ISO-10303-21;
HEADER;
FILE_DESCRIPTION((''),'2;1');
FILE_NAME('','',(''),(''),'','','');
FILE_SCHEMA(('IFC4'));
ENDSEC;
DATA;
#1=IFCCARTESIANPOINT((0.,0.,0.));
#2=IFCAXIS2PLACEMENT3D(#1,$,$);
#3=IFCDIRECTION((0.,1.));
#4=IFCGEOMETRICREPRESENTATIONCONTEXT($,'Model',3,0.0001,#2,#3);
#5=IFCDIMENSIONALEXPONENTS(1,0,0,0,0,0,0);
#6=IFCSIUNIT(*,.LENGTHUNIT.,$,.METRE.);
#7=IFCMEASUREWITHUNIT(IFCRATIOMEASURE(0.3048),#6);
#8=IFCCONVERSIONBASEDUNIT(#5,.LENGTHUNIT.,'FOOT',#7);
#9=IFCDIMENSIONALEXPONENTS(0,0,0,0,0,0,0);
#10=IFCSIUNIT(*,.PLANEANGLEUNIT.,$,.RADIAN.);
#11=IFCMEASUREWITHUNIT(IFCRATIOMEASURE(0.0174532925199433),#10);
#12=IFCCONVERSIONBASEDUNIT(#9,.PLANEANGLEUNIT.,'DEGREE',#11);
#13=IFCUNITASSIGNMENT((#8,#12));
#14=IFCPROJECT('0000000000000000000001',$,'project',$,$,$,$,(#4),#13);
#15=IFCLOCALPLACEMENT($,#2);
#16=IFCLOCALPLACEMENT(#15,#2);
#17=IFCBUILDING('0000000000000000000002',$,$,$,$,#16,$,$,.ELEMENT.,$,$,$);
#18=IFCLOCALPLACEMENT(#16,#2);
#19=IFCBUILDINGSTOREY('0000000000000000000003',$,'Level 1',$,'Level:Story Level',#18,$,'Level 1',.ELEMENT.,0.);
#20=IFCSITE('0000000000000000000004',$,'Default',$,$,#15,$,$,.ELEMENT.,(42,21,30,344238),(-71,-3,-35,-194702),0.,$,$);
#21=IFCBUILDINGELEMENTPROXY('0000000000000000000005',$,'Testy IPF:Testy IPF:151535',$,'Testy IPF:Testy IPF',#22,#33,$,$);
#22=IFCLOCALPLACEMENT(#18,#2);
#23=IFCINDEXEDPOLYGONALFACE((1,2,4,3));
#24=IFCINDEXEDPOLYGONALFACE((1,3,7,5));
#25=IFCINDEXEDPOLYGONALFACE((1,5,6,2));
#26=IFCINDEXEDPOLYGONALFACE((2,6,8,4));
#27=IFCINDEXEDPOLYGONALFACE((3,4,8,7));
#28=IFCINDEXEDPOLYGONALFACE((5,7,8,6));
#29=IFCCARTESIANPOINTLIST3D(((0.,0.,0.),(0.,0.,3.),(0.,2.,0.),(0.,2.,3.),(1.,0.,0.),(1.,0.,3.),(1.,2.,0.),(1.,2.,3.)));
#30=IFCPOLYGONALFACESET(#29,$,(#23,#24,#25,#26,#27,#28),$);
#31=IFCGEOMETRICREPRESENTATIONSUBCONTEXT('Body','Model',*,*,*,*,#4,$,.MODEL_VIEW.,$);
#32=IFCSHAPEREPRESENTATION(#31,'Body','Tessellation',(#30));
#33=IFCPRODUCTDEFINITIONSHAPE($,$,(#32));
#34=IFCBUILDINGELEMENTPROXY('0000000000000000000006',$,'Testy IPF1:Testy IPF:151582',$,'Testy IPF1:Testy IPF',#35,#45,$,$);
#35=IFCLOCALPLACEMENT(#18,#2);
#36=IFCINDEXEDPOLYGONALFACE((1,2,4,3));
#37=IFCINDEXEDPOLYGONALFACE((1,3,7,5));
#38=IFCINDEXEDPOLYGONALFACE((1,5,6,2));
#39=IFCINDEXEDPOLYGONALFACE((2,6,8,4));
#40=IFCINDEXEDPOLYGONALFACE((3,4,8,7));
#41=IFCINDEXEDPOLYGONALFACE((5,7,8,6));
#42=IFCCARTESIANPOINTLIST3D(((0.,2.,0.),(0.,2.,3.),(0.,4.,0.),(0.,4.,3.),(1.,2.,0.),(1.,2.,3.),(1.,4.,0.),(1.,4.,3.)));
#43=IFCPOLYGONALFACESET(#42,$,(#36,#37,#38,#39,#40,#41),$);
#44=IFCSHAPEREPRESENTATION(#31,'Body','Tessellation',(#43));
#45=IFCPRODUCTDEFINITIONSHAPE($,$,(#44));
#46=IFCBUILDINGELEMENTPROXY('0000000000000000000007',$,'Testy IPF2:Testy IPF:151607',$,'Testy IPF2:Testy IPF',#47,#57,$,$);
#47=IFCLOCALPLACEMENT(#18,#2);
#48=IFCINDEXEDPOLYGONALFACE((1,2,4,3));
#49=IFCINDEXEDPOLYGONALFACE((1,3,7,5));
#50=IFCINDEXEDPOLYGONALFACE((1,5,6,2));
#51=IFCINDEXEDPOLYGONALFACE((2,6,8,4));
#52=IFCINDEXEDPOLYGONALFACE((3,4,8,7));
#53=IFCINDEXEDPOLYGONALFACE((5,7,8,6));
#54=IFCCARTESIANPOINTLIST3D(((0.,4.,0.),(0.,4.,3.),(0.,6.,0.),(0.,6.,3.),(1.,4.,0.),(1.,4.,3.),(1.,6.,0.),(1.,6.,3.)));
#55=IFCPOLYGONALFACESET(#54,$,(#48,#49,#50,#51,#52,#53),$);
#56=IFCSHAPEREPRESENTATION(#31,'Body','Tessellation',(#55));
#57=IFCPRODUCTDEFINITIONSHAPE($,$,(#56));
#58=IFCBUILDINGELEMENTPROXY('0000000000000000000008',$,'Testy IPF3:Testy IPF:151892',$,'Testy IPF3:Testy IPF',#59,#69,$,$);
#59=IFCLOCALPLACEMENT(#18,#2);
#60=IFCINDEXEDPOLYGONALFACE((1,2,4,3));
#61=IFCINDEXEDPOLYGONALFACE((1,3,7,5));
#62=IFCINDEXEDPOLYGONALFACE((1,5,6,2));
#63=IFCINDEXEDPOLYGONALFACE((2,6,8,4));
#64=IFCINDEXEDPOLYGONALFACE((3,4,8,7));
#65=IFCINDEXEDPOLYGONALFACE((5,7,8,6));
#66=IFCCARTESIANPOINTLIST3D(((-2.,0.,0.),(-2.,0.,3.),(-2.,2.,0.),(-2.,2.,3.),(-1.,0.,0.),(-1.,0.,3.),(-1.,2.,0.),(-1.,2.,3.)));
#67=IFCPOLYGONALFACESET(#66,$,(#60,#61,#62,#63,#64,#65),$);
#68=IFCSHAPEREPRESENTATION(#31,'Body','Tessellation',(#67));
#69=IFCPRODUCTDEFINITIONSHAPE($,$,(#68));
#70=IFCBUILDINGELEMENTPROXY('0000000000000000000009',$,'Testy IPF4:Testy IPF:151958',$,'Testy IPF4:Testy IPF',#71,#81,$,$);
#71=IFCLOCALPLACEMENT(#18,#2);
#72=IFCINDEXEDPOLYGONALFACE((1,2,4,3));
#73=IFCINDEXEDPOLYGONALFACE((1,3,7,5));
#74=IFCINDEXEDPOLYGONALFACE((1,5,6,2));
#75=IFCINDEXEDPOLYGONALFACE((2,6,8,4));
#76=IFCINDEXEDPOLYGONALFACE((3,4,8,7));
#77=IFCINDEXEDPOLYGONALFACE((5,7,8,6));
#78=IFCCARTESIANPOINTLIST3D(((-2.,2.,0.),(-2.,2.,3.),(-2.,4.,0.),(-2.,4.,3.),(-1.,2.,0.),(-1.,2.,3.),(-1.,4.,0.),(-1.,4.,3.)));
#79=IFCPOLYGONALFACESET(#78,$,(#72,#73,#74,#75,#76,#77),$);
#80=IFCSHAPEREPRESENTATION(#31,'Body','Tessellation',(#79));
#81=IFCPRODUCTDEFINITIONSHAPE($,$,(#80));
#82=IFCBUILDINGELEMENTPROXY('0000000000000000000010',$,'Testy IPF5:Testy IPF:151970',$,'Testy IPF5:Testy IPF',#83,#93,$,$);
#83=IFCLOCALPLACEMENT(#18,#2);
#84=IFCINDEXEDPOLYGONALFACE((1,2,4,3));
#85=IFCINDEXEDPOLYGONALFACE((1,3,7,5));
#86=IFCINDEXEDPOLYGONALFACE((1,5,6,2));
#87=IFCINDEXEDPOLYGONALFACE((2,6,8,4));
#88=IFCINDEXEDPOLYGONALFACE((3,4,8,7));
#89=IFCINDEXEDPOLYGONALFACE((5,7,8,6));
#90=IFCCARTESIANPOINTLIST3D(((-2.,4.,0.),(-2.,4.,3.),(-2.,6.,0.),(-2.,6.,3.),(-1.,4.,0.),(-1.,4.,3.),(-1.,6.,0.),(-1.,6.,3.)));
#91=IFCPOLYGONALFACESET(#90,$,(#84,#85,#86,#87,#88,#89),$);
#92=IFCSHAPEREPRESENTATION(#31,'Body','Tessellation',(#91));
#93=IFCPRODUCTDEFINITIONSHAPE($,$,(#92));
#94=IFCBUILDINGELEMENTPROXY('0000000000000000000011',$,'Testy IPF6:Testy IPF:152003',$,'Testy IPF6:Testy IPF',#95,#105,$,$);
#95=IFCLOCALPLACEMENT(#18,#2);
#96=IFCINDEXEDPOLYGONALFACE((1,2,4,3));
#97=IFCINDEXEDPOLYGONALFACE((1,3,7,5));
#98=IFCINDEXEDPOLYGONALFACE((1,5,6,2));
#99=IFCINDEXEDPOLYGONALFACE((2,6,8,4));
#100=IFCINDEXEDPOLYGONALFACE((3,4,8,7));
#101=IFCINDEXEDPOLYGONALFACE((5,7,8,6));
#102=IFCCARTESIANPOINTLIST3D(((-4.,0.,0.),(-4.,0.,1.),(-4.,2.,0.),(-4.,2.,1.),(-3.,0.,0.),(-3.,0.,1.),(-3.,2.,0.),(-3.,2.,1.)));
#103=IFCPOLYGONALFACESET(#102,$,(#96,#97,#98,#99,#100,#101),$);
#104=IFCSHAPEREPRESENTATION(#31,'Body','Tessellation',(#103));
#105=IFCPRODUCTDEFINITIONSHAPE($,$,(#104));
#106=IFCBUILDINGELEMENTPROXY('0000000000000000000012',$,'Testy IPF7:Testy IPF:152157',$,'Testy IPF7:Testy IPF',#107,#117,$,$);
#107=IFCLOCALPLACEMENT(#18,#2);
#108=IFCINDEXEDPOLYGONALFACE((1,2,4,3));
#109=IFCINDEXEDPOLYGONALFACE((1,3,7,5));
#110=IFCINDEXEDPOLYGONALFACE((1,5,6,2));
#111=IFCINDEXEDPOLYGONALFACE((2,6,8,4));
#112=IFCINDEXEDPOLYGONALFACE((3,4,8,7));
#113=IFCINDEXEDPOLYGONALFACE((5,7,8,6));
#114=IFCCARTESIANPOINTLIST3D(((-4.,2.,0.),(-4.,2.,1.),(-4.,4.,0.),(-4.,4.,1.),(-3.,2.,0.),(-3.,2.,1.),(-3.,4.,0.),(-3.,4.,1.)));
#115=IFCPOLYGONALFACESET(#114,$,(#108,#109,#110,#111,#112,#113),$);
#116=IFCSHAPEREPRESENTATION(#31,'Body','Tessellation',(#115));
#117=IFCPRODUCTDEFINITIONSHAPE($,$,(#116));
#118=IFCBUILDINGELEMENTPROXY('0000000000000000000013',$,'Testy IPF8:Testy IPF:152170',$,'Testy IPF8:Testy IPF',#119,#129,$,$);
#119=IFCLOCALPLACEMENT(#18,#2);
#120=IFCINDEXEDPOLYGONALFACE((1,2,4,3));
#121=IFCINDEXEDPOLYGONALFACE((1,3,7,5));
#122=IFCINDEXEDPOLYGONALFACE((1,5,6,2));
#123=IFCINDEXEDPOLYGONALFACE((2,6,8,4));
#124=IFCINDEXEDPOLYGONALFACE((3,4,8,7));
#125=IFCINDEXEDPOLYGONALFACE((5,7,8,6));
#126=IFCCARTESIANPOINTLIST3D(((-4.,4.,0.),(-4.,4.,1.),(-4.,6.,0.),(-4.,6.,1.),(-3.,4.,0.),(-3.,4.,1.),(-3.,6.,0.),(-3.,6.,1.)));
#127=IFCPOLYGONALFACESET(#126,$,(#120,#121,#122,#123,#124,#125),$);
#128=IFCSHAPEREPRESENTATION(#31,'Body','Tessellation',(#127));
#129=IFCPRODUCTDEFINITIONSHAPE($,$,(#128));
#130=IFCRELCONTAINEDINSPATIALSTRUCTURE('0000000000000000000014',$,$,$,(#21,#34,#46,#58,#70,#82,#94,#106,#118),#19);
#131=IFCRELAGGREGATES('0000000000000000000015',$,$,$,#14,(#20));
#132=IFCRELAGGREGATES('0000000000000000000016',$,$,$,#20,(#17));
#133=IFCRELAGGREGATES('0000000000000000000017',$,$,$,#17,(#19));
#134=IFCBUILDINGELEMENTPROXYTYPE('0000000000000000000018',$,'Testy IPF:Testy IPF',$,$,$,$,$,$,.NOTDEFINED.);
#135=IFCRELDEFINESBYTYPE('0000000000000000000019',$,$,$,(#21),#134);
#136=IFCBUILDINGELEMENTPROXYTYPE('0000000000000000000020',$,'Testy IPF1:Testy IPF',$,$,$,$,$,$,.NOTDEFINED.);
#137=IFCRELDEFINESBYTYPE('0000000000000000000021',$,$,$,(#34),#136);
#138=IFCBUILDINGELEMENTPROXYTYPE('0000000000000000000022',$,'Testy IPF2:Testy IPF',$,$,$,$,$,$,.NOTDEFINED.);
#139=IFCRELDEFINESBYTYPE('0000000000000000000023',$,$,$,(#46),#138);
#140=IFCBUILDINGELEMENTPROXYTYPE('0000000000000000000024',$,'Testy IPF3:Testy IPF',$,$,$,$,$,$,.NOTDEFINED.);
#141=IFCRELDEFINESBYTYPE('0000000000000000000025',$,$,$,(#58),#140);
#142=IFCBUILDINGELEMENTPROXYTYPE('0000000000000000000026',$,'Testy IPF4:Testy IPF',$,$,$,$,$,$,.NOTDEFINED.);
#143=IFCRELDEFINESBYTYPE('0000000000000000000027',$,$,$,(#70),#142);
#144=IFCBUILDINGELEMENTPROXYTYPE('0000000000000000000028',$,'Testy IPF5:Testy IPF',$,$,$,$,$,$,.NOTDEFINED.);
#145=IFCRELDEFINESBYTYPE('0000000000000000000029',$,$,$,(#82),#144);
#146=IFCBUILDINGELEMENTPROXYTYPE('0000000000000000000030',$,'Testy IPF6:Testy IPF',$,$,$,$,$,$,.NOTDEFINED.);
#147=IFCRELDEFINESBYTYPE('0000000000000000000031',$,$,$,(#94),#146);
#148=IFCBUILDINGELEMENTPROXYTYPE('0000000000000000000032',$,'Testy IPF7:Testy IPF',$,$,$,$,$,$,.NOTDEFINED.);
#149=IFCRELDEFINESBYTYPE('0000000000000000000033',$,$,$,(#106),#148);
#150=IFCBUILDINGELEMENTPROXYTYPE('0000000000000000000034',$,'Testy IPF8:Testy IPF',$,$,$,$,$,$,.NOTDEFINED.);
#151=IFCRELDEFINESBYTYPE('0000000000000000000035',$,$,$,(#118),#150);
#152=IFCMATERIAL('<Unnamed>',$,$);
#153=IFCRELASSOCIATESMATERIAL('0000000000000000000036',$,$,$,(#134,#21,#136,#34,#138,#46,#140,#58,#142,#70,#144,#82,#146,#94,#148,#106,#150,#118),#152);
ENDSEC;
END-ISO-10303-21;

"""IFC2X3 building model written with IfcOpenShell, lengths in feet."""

from ifc_helpers import new_model, entity, si_unit, converted_unit, direction, frame, frame_2d, origin, origin_2d_with_axis, place, context, subcontext, project, spatial, rectangle, extrude, source, transform, mapped, material, type_object, type_shapes, element, save


model = new_model("IFC2X3")

# Units and contexts
model_context = context("Model", 3, precision=0.0001, world=origin(), true_north=direction((0.0, 1.0)))
body_context = subcontext(model_context, "Body", "Model", "MODEL_VIEW")
ifc_project = project(units=[converted_unit("LENGTHUNIT", "FOOT", entity("IfcRatioMeasure", 0.3048), si_unit("LENGTHUNIT", "METRE"), dimensions=[1, 0, 0, 0, 0, 0, 0]), converted_unit("PLANEANGLEUNIT", "DEGREE", entity("IfcRatioMeasure", 0.0174532925199433), si_unit("PLANEANGLEUNIT", "RADIAN"), dimensions=[0, 0, 0, 0, 0, 0, 0])], contexts=[model_context])

# Site, building, storey
site_placement = place(None, origin())
site = spatial("IfcSite", under=ifc_project, at=site_placement, Name="Default", CompositionType="ELEMENT", RefLatitude=(42, 21, 30, 344238), RefLongitude=(-71, -3, -35, -194702), RefElevation=0.0)
building_placement = place(site_placement, origin())
building = spatial("IfcBuilding", under=site, at=building_placement, CompositionType="ELEMENT")
storey_placement = place(building_placement, origin())
storey = spatial("IfcBuildingStorey", under=building, at=storey_placement, Name="Level 1", ObjectType="Level:Story Level", LongName="Level 1", CompositionType="ELEMENT", Elevation=0.0)

# Building element proxies
ifc_material = material(Name="<Unnamed>")
building_element_proxy_type_1 = type_object("IfcBuildingElementProxyType", Name="Testy IPF:Testy IPF", PredefinedType="NOTDEFINED", material=ifc_material)
shared_shape_1 = source(origin(), body_context, "Body", "SweptSolid", [
    extrude(rectangle(XDim=2.0, YDim=1.0, at=frame_2d((0.0, 0.0), x_axis=(1.0, 0.0))), frame((0.5, 1.0, 0.0), z_axis=(0.0, 0.0, 1.0), x_axis=(0.0, 1.0, 0.0)), (0.0, 0.0, 1.0), 3.0),
])
type_shapes(building_element_proxy_type_1, [shared_shape_1])
proxy_1_placement = place(storey_placement, origin())
element("IfcBuildingElementProxy", 1, at=proxy_1_placement, inside=storey, type_object=building_element_proxy_type_1, material=ifc_material, Name="Testy IPF:Testy IPF:151535", ObjectType="Testy IPF:Testy IPF", context=body_context, shape_type="MappedRepresentation", body=[
    mapped(shared_shape_1, transform((0.0, 0.0, 0.0), scale=1.0)),
])
building_element_proxy_type_2 = type_object("IfcBuildingElementProxyType", Name="Testy IPF1:Testy IPF", PredefinedType="NOTDEFINED", material=ifc_material)
shared_shape_2 = source(origin(), body_context, "Body", "SweptSolid", [
    extrude(rectangle(XDim=2.0, YDim=1.0, at=origin_2d_with_axis()), frame((0.5, 3.0, 0.0), z_axis=(0.0, 0.0, 1.0), x_axis=(0.0, 1.0, 0.0)), (0.0, 0.0, 1.0), 3.0),
])
type_shapes(building_element_proxy_type_2, [shared_shape_2])
proxy_2_placement = place(storey_placement, origin())
element("IfcBuildingElementProxy", 2, at=proxy_2_placement, inside=storey, type_object=building_element_proxy_type_2, material=ifc_material, Name="Testy IPF1:Testy IPF:151582", ObjectType="Testy IPF1:Testy IPF", context=body_context, shape_type="MappedRepresentation", body=[
    mapped(shared_shape_2, transform((0.0, 0.0, 0.0), scale=1.0)),
])
building_element_proxy_type_3 = type_object("IfcBuildingElementProxyType", Name="Testy IPF2:Testy IPF", PredefinedType="NOTDEFINED", material=ifc_material)
shared_shape_3 = source(origin(), body_context, "Body", "SweptSolid", [
    extrude(rectangle(XDim=2.0, YDim=1.0, at=origin_2d_with_axis()), frame((0.5, 5.0, 0.0), z_axis=(0.0, 0.0, 1.0), x_axis=(0.0, 1.0, 0.0)), (0.0, 0.0, 1.0), 3.0),
])
type_shapes(building_element_proxy_type_3, [shared_shape_3])
proxy_3_placement = place(storey_placement, origin())
element("IfcBuildingElementProxy", 3, at=proxy_3_placement, inside=storey, type_object=building_element_proxy_type_3, material=ifc_material, Name="Testy IPF2:Testy IPF:151607", ObjectType="Testy IPF2:Testy IPF", context=body_context, shape_type="MappedRepresentation", body=[
    mapped(shared_shape_3, transform((0.0, 0.0, 0.0), scale=1.0)),
])
building_element_proxy_type_4 = type_object("IfcBuildingElementProxyType", Name="Testy IPF3:Testy IPF", PredefinedType="NOTDEFINED", material=ifc_material)
shared_shape_4 = source(origin(), body_context, "Body", "SweptSolid", [
    extrude(rectangle(XDim=2.0, YDim=1.0, at=origin_2d_with_axis()), frame((-1.5, 1.0, 0.0), z_axis=(0.0, 0.0, 1.0), x_axis=(0.0, 1.0, 0.0)), (0.0, 0.0, 1.0), 3.0),
])
type_shapes(building_element_proxy_type_4, [shared_shape_4])
proxy_4_placement = place(storey_placement, origin())
element("IfcBuildingElementProxy", 4, at=proxy_4_placement, inside=storey, type_object=building_element_proxy_type_4, material=ifc_material, Name="Testy IPF3:Testy IPF:151892", ObjectType="Testy IPF3:Testy IPF", context=body_context, shape_type="MappedRepresentation", body=[
    mapped(shared_shape_4, transform((0.0, 0.0, 0.0), scale=1.0)),
])
building_element_proxy_type_5 = type_object("IfcBuildingElementProxyType", Name="Testy IPF4:Testy IPF", PredefinedType="NOTDEFINED", material=ifc_material)
shared_shape_5 = source(origin(), body_context, "Body", "SweptSolid", [
    extrude(rectangle(XDim=2.0, YDim=1.0, at=frame_2d((0.0, 0.0), x_axis=(1.0, 0.0))), frame((-1.5, 3.0, 0.0), z_axis=(0.0, 0.0, 1.0), x_axis=(0.0, 1.0, 0.0)), (0.0, 0.0, 1.0), 3.0),
])
type_shapes(building_element_proxy_type_5, [shared_shape_5])
proxy_5_placement = place(storey_placement, origin())
element("IfcBuildingElementProxy", 5, at=proxy_5_placement, inside=storey, type_object=building_element_proxy_type_5, material=ifc_material, Name="Testy IPF4:Testy IPF:151958", ObjectType="Testy IPF4:Testy IPF", context=body_context, shape_type="MappedRepresentation", body=[
    mapped(shared_shape_5, transform((0.0, 0.0, 0.0), scale=1.0)),
])
building_element_proxy_type_6 = type_object("IfcBuildingElementProxyType", Name="Testy IPF5:Testy IPF", PredefinedType="NOTDEFINED", material=ifc_material)
shared_shape_6 = source(origin(), body_context, "Body", "SweptSolid", [
    extrude(rectangle(XDim=2.0, YDim=1.0, at=origin_2d_with_axis()), frame((-1.5, 5.0, 0.0), z_axis=(0.0, 0.0, 1.0), x_axis=(0.0, 1.0, 0.0)), (0.0, 0.0, 1.0), 3.0),
])
type_shapes(building_element_proxy_type_6, [shared_shape_6])
proxy_6_placement = place(storey_placement, origin())
element("IfcBuildingElementProxy", 6, at=proxy_6_placement, inside=storey, type_object=building_element_proxy_type_6, material=ifc_material, Name="Testy IPF5:Testy IPF:151970", ObjectType="Testy IPF5:Testy IPF", context=body_context, shape_type="MappedRepresentation", body=[
    mapped(shared_shape_6, transform((0.0, 0.0, 0.0), scale=1.0)),
])
building_element_proxy_type_7 = type_object("IfcBuildingElementProxyType", Name="Testy IPF6:Testy IPF", PredefinedType="NOTDEFINED", material=ifc_material)
shared_shape_7 = source(origin(), body_context, "Body", "SweptSolid", [
    extrude(rectangle(XDim=2.0, YDim=1.0, at=frame_2d((0.0, 0.0), x_axis=(1.0, 0.0))), frame((-3.5, 1.0, 0.0), z_axis=(0.0, 0.0, 1.0), x_axis=(0.0, 1.0, 0.0)), (0.0, 0.0, 1.0), 1.0),
])
type_shapes(building_element_proxy_type_7, [shared_shape_7])
proxy_7_placement = place(storey_placement, origin())
element("IfcBuildingElementProxy", 7, at=proxy_7_placement, inside=storey, type_object=building_element_proxy_type_7, material=ifc_material, Name="Testy IPF6:Testy IPF:152003", ObjectType="Testy IPF6:Testy IPF", context=body_context, shape_type="MappedRepresentation", body=[
    mapped(shared_shape_7, transform((0.0, 0.0, 0.0), scale=1.0)),
])
building_element_proxy_type_8 = type_object("IfcBuildingElementProxyType", Name="Testy IPF7:Testy IPF", PredefinedType="NOTDEFINED", material=ifc_material)
shared_shape_8 = source(origin(), body_context, "Body", "SweptSolid", [
    extrude(rectangle(XDim=2.0, YDim=1.0, at=frame_2d((0.0, 0.0), x_axis=(1.0, 0.0))), frame((-3.5, 3.0, 0.0), z_axis=(0.0, 0.0, 1.0), x_axis=(0.0, 1.0, 0.0)), (0.0, 0.0, 1.0), 1.0),
])
type_shapes(building_element_proxy_type_8, [shared_shape_8])
proxy_8_placement = place(storey_placement, origin())
element("IfcBuildingElementProxy", 8, at=proxy_8_placement, inside=storey, type_object=building_element_proxy_type_8, material=ifc_material, Name="Testy IPF7:Testy IPF:152157", ObjectType="Testy IPF7:Testy IPF", context=body_context, shape_type="MappedRepresentation", body=[
    mapped(shared_shape_8, transform((0.0, 0.0, 0.0), scale=1.0)),
])
building_element_proxy_type_9 = type_object("IfcBuildingElementProxyType", Name="Testy IPF8:Testy IPF", PredefinedType="NOTDEFINED", material=ifc_material)
shared_shape_9 = source(origin(), body_context, "Body", "SweptSolid", [
    extrude(rectangle(XDim=2.0, YDim=1.0, at=origin_2d_with_axis()), frame((-3.5, 5.0, 0.0), z_axis=(0.0, 0.0, 1.0), x_axis=(0.0, 1.0, 0.0)), (0.0, 0.0, 1.0), 1.0),
])
type_shapes(building_element_proxy_type_9, [shared_shape_9])
proxy_9_placement = place(storey_placement, origin())
element("IfcBuildingElementProxy", 9, at=proxy_9_placement, inside=storey, type_object=building_element_proxy_type_9, material=ifc_material, Name="Testy IPF8:Testy IPF:152170", ObjectType="Testy IPF8:Testy IPF", context=body_context, shape_type="MappedRepresentation", body=[
    mapped(shared_shape_9, transform((0.0, 0.0, 0.0), scale=1.0)),
])

save(model, "model.ifc")
